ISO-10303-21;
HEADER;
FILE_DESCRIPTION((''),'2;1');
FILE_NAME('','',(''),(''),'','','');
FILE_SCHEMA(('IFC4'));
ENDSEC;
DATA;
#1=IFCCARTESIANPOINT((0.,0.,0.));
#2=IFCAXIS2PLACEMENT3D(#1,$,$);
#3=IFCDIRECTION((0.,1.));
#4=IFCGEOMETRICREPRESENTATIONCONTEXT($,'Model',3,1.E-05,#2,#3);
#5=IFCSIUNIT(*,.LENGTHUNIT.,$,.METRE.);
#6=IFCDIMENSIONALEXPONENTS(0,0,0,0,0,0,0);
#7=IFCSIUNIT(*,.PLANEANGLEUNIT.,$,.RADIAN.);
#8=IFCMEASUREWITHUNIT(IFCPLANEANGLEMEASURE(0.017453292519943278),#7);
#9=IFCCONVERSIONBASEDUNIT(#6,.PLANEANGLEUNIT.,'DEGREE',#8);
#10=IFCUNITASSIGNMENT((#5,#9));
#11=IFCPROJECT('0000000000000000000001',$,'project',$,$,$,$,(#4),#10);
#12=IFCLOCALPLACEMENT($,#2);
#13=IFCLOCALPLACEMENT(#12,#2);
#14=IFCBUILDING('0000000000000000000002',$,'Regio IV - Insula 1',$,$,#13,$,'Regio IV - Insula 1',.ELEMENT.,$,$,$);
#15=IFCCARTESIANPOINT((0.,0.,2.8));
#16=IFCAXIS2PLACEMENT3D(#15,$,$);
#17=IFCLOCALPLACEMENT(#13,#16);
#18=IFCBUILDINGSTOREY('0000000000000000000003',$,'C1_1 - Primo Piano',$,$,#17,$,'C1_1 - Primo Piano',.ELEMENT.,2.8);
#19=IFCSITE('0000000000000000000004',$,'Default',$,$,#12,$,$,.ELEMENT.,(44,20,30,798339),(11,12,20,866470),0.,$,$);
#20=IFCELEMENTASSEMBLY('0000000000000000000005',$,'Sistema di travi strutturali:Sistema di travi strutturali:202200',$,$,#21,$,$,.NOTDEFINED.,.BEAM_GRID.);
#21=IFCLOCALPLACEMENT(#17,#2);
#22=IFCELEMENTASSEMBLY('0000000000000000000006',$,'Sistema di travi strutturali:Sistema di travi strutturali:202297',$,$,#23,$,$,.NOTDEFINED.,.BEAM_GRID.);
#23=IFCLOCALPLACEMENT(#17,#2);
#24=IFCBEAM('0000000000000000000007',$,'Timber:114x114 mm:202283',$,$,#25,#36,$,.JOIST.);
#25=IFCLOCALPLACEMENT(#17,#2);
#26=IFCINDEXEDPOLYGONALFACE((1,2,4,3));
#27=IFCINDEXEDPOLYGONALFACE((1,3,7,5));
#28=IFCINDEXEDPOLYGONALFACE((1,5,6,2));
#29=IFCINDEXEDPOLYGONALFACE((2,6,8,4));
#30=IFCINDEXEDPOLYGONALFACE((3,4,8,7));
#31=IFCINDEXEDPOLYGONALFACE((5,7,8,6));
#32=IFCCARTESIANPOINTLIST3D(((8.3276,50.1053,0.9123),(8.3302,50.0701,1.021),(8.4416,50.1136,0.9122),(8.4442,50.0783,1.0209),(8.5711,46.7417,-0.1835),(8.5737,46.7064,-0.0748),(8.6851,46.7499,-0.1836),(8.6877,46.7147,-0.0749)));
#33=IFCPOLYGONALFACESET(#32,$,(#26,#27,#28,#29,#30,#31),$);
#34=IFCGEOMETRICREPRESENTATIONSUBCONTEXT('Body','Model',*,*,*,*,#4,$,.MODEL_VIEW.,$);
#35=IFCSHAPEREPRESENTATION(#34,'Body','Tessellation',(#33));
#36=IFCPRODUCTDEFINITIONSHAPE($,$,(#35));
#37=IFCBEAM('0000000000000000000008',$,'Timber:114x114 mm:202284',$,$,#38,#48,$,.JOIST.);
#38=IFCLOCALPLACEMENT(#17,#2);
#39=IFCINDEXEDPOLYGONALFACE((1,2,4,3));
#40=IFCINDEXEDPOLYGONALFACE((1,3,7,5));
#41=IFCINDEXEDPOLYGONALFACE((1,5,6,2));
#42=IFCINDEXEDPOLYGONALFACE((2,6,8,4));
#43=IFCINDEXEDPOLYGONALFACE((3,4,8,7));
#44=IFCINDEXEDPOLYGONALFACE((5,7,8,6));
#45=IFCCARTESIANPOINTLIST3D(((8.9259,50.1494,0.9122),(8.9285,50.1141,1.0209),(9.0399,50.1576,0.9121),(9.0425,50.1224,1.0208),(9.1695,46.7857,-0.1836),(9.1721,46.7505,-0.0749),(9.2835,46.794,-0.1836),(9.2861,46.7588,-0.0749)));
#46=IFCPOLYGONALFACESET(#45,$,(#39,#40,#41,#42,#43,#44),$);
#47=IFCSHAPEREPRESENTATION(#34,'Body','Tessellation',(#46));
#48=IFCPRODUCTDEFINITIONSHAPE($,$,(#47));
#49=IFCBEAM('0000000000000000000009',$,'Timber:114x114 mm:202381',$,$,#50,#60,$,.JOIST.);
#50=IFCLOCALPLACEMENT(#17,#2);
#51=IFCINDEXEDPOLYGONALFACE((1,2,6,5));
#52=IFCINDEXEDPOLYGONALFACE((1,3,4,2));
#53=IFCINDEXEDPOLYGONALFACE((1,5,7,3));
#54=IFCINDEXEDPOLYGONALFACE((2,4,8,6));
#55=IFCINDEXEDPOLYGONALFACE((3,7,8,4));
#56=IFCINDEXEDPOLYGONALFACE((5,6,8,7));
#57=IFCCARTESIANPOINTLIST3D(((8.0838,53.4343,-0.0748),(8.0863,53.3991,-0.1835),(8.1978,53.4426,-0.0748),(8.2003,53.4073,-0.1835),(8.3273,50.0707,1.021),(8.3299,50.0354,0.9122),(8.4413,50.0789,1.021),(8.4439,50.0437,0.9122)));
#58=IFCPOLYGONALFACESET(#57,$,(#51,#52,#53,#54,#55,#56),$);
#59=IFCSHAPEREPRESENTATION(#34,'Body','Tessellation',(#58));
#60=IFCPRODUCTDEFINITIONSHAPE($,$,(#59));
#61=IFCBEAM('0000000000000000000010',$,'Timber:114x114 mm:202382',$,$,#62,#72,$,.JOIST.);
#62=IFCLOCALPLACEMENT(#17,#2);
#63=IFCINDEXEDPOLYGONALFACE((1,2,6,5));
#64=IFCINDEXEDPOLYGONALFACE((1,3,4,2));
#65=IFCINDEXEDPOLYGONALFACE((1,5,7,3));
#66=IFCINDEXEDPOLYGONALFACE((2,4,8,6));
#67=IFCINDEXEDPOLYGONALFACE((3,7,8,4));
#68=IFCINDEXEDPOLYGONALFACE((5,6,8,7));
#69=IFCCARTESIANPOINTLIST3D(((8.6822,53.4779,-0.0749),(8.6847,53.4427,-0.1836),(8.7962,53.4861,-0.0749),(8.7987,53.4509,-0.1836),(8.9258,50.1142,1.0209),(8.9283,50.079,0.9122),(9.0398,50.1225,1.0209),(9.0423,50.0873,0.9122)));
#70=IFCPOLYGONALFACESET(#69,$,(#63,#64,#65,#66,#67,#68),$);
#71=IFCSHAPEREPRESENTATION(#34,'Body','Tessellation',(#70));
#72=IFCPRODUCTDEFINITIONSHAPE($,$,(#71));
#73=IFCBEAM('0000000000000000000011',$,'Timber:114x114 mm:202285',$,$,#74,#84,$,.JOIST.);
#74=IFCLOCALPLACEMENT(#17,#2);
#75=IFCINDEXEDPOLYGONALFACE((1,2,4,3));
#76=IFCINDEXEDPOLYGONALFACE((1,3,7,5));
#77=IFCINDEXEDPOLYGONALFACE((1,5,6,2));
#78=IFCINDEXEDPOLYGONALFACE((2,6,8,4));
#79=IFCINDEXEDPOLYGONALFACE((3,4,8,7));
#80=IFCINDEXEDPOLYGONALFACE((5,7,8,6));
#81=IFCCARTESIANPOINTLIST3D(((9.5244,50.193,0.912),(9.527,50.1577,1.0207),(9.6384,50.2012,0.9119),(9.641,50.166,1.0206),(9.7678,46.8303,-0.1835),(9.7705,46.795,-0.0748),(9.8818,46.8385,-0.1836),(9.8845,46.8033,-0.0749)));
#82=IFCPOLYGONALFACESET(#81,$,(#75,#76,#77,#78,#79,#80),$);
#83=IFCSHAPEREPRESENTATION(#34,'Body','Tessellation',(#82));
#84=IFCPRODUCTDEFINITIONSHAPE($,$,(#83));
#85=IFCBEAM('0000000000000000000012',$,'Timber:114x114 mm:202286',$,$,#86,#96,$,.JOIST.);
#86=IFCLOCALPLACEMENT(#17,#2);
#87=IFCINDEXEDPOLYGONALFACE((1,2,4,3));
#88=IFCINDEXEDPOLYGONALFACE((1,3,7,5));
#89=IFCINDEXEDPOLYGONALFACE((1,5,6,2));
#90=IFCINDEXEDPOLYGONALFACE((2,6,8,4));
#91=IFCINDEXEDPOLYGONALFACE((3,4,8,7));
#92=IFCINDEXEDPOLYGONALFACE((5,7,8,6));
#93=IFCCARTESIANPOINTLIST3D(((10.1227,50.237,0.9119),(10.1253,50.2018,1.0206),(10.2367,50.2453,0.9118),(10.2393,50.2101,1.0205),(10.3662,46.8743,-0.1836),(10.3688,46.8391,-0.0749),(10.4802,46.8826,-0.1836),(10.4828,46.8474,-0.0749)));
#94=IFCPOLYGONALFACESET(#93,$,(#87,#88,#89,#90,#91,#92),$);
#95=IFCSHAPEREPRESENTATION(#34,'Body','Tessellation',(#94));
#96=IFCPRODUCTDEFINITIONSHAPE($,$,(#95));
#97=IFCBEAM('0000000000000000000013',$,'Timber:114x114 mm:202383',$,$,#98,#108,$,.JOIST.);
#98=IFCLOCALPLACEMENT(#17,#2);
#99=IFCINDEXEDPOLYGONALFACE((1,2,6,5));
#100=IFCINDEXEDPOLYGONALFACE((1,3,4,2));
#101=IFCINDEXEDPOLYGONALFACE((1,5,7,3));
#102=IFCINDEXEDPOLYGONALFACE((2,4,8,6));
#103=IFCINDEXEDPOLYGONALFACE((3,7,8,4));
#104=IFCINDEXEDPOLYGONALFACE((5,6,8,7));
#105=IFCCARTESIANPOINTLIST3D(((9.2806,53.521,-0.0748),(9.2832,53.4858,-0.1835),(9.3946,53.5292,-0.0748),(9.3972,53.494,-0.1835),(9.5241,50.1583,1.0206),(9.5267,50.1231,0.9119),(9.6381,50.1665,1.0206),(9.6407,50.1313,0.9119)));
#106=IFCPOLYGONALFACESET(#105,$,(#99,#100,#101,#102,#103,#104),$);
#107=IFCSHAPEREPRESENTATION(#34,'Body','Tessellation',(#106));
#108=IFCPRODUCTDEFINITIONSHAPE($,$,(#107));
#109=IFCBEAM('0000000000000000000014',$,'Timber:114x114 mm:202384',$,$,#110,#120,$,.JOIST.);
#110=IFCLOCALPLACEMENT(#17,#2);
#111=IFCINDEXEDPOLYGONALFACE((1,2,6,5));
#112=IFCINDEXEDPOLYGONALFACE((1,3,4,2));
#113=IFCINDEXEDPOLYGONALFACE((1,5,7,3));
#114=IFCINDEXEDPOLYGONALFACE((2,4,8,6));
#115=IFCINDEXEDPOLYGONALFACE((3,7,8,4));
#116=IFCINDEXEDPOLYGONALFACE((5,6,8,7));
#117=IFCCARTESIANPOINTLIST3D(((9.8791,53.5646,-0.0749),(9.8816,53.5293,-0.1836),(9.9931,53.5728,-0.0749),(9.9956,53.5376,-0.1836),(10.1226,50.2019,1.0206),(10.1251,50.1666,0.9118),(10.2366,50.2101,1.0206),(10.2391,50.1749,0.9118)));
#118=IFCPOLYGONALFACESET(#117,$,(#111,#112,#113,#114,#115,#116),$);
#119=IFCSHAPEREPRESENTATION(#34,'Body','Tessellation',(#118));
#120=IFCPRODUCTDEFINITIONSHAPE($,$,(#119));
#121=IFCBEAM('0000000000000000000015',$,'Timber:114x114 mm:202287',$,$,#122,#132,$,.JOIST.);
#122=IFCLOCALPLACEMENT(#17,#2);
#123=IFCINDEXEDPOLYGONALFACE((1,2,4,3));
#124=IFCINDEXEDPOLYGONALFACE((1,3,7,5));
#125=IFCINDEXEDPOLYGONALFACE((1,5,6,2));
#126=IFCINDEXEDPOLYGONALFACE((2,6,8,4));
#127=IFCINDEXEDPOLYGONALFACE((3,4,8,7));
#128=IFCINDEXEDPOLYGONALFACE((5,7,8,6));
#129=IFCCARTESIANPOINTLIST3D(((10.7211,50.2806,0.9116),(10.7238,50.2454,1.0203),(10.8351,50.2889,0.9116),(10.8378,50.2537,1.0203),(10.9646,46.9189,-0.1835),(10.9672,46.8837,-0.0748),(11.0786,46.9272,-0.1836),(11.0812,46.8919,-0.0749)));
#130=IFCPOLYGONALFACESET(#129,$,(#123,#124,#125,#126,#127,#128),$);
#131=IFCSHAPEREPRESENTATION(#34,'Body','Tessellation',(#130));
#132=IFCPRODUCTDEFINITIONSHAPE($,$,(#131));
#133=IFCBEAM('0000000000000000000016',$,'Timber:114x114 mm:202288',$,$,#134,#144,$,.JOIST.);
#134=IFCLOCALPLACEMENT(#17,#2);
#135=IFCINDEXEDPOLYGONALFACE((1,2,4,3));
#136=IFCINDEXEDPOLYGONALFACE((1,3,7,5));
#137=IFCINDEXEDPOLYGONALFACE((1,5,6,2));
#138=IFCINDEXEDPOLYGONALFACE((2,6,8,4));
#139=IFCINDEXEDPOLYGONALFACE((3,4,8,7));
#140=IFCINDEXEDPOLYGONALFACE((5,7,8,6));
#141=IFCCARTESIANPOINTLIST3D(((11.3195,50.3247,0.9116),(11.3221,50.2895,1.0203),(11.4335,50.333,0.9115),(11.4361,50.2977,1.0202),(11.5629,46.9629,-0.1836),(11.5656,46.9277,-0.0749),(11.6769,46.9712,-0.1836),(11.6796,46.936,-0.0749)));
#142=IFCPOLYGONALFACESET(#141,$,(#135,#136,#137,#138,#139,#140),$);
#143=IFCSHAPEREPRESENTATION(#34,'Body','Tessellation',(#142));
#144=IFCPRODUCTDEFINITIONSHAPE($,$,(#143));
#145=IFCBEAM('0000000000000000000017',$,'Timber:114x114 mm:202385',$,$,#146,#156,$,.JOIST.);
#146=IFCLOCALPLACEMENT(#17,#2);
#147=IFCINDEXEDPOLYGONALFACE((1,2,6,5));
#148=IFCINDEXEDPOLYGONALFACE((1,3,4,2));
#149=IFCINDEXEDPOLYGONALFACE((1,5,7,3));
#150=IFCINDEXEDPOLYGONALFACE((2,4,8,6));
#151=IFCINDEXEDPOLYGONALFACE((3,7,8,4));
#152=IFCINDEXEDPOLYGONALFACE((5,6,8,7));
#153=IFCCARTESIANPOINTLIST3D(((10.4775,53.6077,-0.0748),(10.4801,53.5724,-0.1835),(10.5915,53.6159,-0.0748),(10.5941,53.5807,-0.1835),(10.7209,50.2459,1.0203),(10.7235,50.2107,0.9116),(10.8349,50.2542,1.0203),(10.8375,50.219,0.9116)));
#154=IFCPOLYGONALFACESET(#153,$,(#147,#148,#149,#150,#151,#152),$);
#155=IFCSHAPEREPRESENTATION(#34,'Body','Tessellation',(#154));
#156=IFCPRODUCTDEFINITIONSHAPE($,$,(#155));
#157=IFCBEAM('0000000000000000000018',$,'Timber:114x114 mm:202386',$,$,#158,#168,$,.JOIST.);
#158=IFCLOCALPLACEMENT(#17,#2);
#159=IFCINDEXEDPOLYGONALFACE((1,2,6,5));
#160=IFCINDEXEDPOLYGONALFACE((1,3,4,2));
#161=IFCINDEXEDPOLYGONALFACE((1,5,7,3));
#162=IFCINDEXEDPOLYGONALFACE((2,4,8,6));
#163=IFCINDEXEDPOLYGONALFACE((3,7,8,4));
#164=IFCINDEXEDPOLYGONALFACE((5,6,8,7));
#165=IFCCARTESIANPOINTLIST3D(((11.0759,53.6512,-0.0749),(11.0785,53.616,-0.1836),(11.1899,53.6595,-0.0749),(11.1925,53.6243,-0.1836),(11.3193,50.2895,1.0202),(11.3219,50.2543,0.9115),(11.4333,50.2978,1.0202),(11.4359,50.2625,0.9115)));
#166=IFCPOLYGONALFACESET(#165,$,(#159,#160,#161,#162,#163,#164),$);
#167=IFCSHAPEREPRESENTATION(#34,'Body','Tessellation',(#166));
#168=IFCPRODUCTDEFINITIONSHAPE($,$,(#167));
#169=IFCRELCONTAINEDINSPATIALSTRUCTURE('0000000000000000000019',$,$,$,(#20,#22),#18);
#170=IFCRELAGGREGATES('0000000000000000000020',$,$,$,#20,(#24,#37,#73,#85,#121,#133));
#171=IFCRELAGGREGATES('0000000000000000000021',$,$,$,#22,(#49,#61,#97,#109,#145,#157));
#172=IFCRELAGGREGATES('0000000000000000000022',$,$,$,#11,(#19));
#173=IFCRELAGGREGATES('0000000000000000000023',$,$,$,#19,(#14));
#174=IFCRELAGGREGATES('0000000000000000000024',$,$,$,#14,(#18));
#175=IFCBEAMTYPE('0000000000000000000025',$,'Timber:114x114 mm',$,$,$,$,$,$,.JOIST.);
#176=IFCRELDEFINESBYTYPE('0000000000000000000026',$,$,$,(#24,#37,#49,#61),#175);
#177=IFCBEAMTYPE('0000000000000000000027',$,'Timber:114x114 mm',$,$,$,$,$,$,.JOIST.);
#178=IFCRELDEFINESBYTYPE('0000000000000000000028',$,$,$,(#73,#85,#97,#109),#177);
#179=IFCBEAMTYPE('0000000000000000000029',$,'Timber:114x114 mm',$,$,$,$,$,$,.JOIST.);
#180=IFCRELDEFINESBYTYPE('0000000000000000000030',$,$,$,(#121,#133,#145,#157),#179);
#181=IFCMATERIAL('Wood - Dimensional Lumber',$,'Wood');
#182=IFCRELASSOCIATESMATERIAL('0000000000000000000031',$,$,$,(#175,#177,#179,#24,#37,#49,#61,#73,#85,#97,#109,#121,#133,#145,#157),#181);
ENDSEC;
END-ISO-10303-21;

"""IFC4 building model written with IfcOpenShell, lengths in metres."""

from ifc_helpers import new_model, entity, si_unit, converted_unit, direction, frame, origin, origin_2d_with_axis, place, context, subcontext, project, spatial, rectangle, extrude, source, transform, mapped, material, material_profile, profile_set, profile_usage, type_object, type_shapes, element, aggregate, save


model = new_model("IFC4")

# Units and contexts
model_context = context("Model", 3, precision=1e-05, world=origin(), true_north=direction((0.0, 1.0)))
body_context = subcontext(model_context, "Body", "Model", "MODEL_VIEW")
ifc_project = project(units=[si_unit("LENGTHUNIT", "METRE"), converted_unit("PLANEANGLEUNIT", "DEGREE", entity("IfcPlaneAngleMeasure", 0.017453292519943278), si_unit("PLANEANGLEUNIT", "RADIAN"), dimensions=[0, 0, 0, 0, 0, 0, 0])], contexts=[model_context])

# Site, building, storey
site_placement = place(None, origin())
site = spatial("IfcSite", under=ifc_project, at=site_placement, Name="Default", CompositionType="ELEMENT", RefLatitude=(44, 20, 30, 798339), RefLongitude=(11, 12, 20, 866470), RefElevation=0.0)
building_placement = place(site_placement, origin())
building = spatial("IfcBuilding", under=site, at=building_placement, Name="Regio IV - Insula 1", LongName="Regio IV - Insula 1", CompositionType="ELEMENT")
storey_placement = place(building_placement, frame((0.0, 0.0, 2.8)))
storey = spatial("IfcBuildingStorey", under=building, at=storey_placement, Name="C1_1 - Primo Piano", LongName="C1_1 - Primo Piano", CompositionType="ELEMENT", Elevation=2.8)

# Shared definitions
ifc_material = material(Name="Wood - Dimensional Lumber", Category="Wood")
ifc_material_profile = material_profile(ifc_material, rectangle(XDim=5.294, YDim=0.1143, at=origin_2d_with_axis()), Name="114x114 mm")
ifc_profile_set = profile_set([ifc_material_profile], Name="114x114 mm")
ifc_profile_usage = profile_usage(ifc_profile_set, cardinal=8)

# Element assemblies
assembly_1_placement = place(storey_placement, origin())
assembly_1 = element("IfcElementAssembly", 1, at=assembly_1_placement, inside=storey, Name="Sistema di travi strutturali:Sistema di travi strutturali:202200", AssemblyPlace="NOTDEFINED", PredefinedType="BEAM_GRID")
assembly_2_placement = place(storey_placement, origin())
assembly_2 = element("IfcElementAssembly", 2, at=assembly_2_placement, inside=storey, Name="Sistema di travi strutturali:Sistema di travi strutturali:202297", AssemblyPlace="NOTDEFINED", PredefinedType="BEAM_GRID")

# Beams
beam_type_1 = type_object("IfcBeamType", Name="Timber:114x114 mm", PredefinedType="JOIST", material=ifc_profile_set)
shared_shape_1 = source(origin(), body_context, "Body", "SweptSolid", [
    extrude(rectangle(XDim=3.546, YDim=0.1143, at=origin_2d_with_axis()), frame((0.0, 0.0, -0.0572), z_axis=(0.0, 0.0, 1.0), x_axis=(-1.0, 0.0, 0.0)), (0.0, 0.0, 1.0), 0.1143),
])
type_shapes(beam_type_1, [shared_shape_1])
beam_1_placement = place(assembly_1_placement, frame((8.5076, 48.41, 0.4187), z_axis=(0.022823, -0.308173, 0.951057), x_axis=(0.068685, -0.948573, -0.309017)))
beam_1 = element("IfcBeam", 3, at=beam_1_placement, type_object=beam_type_1, material=ifc_profile_usage, Name="Timber:114x114 mm:202283", PredefinedType="JOIST", context=body_context, shape_type="MappedRepresentation", body=[
    mapped(shared_shape_1, transform((0.0, 0.0, 0.0), scale=1.0)),
])
beam_2_placement = place(assembly_1_placement, frame((9.106, 48.4541, 0.4186), z_axis=(0.022823, -0.308173, 0.951057), x_axis=(0.068685, -0.948573, -0.309017)))
beam_2 = element("IfcBeam", 4, at=beam_2_placement, type_object=beam_type_1, material=ifc_profile_usage, Name="Timber:114x114 mm:202284", PredefinedType="JOIST", context=body_context, shape_type="MappedRepresentation", body=[
    mapped(shared_shape_1, transform((0.0, 0.0, 0.0), scale=1.0)),
])
beam_3_placement = place(assembly_2_placement, frame((8.2638, 51.739, 0.4187), z_axis=(-0.022317, 0.30821, 0.951057), x_axis=(0.068685, -0.948573, 0.309017)))
beam_3 = element("IfcBeam", 5, at=beam_3_placement, type_object=beam_type_1, material=ifc_profile_usage, Name="Timber:114x114 mm:202381", PredefinedType="JOIST", context=body_context, shape_type="MappedRepresentation", body=[
    mapped(shared_shape_1, transform((0.0, 0.0, 0.0), scale=1.0)),
])
beam_4_placement = place(assembly_2_placement, frame((8.8623, 51.7826, 0.4186), z_axis=(-0.022317, 0.30821, 0.951057), x_axis=(0.068685, -0.948573, 0.309017)))
beam_4 = element("IfcBeam", 6, at=beam_4_placement, type_object=beam_type_1, material=ifc_profile_usage, Name="Timber:114x114 mm:202382", PredefinedType="JOIST", context=body_context, shape_type="MappedRepresentation", body=[
    mapped(shared_shape_1, transform((0.0, 0.0, 0.0), scale=1.0)),
])
beam_type_2 = type_object("IfcBeamType", Name="Timber:114x114 mm", PredefinedType="JOIST", material=ifc_profile_set)
shared_shape_2 = source(origin(), body_context, "Body", "SweptSolid", [
    extrude(rectangle(XDim=3.545, YDim=0.1143, at=origin_2d_with_axis()), frame((0.0, 0.0, -0.0572), z_axis=(0.0, 0.0, 1.0), x_axis=(-1.0, 0.0, 0.0)), (0.0, 0.0, 1.0), 0.1143),
])
type_shapes(beam_type_2, [shared_shape_2])
beam_5_placement = place(assembly_1_placement, frame((9.7044, 48.4981, 0.4185), z_axis=(0.022823, -0.308173, 0.951057), x_axis=(0.068685, -0.948573, -0.309017)))
beam_5 = element("IfcBeam", 7, at=beam_5_placement, type_object=beam_type_2, material=ifc_profile_usage, Name="Timber:114x114 mm:202285", PredefinedType="JOIST", context=body_context, shape_type="MappedRepresentation", body=[
    mapped(shared_shape_2, transform((0.0, 0.0, 0.0), scale=1.0)),
])
beam_6_placement = place(assembly_1_placement, frame((10.3028, 48.5422, 0.4185), z_axis=(0.022823, -0.308173, 0.951057), x_axis=(0.068685, -0.948573, -0.309017)))
beam_6 = element("IfcBeam", 8, at=beam_6_placement, type_object=beam_type_2, material=ifc_profile_usage, Name="Timber:114x114 mm:202286", PredefinedType="JOIST", context=body_context, shape_type="MappedRepresentation", body=[
    mapped(shared_shape_2, transform((0.0, 0.0, 0.0), scale=1.0)),
])
beam_7_placement = place(assembly_2_placement, frame((9.4607, 51.8262, 0.4186), z_axis=(-0.022317, 0.30821, 0.951057), x_axis=(0.068685, -0.948573, 0.309017)))
beam_7 = element("IfcBeam", 9, at=beam_7_placement, type_object=beam_type_2, material=ifc_profile_usage, Name="Timber:114x114 mm:202383", PredefinedType="JOIST", context=body_context, shape_type="MappedRepresentation", body=[
    mapped(shared_shape_2, transform((0.0, 0.0, 0.0), scale=1.0)),
])
beam_8_placement = place(assembly_2_placement, frame((10.0591, 51.8697, 0.4185), z_axis=(-0.022317, 0.30821, 0.951057), x_axis=(0.068685, -0.948573, 0.309017)))
beam_8 = element("IfcBeam", 10, at=beam_8_placement, type_object=beam_type_2, material=ifc_profile_usage, Name="Timber:114x114 mm:202384", PredefinedType="JOIST", context=body_context, shape_type="MappedRepresentation", body=[
    mapped(shared_shape_2, transform((0.0, 0.0, 0.0), scale=1.0)),
])
beam_type_3 = type_object("IfcBeamType", Name="Timber:114x114 mm", PredefinedType="JOIST", material=ifc_profile_set)
shared_shape_3 = source(origin(), body_context, "Body", "SweptSolid", [
    extrude(rectangle(XDim=3.544, YDim=0.1143, at=origin_2d_with_axis()), frame((0.0, 0.0, -0.0572), z_axis=(0.0, 0.0, 1.0), x_axis=(-1.0, 0.0, 0.0)), (0.0, 0.0, 1.0), 0.1143),
])
type_shapes(beam_type_3, [shared_shape_3])
beam_9_placement = place(assembly_1_placement, frame((10.9012, 48.5863, 0.4184), z_axis=(0.022823, -0.308173, 0.951057), x_axis=(0.068685, -0.948573, -0.309017)))
beam_9 = element("IfcBeam", 11, at=beam_9_placement, type_object=beam_type_3, material=ifc_profile_usage, Name="Timber:114x114 mm:202287", PredefinedType="JOIST", context=body_context, shape_type="MappedRepresentation", body=[
    mapped(shared_shape_3, transform((0.0, 0.0, 0.0), scale=1.0)),
])
beam_10_placement = place(assembly_1_placement, frame((11.4995, 48.6303, 0.4183), z_axis=(0.022823, -0.308173, 0.951057), x_axis=(0.068685, -0.948573, -0.309017)))
beam_10 = element("IfcBeam", 12, at=beam_10_placement, type_object=beam_type_3, material=ifc_profile_usage, Name="Timber:114x114 mm:202288", PredefinedType="JOIST", context=body_context, shape_type="MappedRepresentation", body=[
    mapped(shared_shape_3, transform((0.0, 0.0, 0.0), scale=1.0)),
])
aggregate(assembly_1, [beam_1, beam_2, beam_5, beam_6, beam_9, beam_10])
beam_11_placement = place(assembly_2_placement, frame((10.6575, 51.9133, 0.4184), z_axis=(-0.022317, 0.30821, 0.951057), x_axis=(0.068685, -0.948573, 0.309017)))
beam_11 = element("IfcBeam", 13, at=beam_11_placement, type_object=beam_type_3, material=ifc_profile_usage, Name="Timber:114x114 mm:202385", PredefinedType="JOIST", context=body_context, shape_type="MappedRepresentation", body=[
    mapped(shared_shape_3, transform((0.0, 0.0, 0.0), scale=1.0)),
])
beam_12_placement = place(assembly_2_placement, frame((11.2559, 51.9569, 0.4183), z_axis=(-0.022317, 0.30821, 0.951057), x_axis=(0.068685, -0.948573, 0.309017)))
beam_12 = element("IfcBeam", 14, at=beam_12_placement, type_object=beam_type_3, material=ifc_profile_usage, Name="Timber:114x114 mm:202386", PredefinedType="JOIST", context=body_context, shape_type="MappedRepresentation", body=[
    mapped(shared_shape_3, transform((0.0, 0.0, 0.0), scale=1.0)),
])
aggregate(assembly_2, [beam_3, beam_4, beam_7, beam_8, beam_11, beam_12])

save(model, "model.ifc")
